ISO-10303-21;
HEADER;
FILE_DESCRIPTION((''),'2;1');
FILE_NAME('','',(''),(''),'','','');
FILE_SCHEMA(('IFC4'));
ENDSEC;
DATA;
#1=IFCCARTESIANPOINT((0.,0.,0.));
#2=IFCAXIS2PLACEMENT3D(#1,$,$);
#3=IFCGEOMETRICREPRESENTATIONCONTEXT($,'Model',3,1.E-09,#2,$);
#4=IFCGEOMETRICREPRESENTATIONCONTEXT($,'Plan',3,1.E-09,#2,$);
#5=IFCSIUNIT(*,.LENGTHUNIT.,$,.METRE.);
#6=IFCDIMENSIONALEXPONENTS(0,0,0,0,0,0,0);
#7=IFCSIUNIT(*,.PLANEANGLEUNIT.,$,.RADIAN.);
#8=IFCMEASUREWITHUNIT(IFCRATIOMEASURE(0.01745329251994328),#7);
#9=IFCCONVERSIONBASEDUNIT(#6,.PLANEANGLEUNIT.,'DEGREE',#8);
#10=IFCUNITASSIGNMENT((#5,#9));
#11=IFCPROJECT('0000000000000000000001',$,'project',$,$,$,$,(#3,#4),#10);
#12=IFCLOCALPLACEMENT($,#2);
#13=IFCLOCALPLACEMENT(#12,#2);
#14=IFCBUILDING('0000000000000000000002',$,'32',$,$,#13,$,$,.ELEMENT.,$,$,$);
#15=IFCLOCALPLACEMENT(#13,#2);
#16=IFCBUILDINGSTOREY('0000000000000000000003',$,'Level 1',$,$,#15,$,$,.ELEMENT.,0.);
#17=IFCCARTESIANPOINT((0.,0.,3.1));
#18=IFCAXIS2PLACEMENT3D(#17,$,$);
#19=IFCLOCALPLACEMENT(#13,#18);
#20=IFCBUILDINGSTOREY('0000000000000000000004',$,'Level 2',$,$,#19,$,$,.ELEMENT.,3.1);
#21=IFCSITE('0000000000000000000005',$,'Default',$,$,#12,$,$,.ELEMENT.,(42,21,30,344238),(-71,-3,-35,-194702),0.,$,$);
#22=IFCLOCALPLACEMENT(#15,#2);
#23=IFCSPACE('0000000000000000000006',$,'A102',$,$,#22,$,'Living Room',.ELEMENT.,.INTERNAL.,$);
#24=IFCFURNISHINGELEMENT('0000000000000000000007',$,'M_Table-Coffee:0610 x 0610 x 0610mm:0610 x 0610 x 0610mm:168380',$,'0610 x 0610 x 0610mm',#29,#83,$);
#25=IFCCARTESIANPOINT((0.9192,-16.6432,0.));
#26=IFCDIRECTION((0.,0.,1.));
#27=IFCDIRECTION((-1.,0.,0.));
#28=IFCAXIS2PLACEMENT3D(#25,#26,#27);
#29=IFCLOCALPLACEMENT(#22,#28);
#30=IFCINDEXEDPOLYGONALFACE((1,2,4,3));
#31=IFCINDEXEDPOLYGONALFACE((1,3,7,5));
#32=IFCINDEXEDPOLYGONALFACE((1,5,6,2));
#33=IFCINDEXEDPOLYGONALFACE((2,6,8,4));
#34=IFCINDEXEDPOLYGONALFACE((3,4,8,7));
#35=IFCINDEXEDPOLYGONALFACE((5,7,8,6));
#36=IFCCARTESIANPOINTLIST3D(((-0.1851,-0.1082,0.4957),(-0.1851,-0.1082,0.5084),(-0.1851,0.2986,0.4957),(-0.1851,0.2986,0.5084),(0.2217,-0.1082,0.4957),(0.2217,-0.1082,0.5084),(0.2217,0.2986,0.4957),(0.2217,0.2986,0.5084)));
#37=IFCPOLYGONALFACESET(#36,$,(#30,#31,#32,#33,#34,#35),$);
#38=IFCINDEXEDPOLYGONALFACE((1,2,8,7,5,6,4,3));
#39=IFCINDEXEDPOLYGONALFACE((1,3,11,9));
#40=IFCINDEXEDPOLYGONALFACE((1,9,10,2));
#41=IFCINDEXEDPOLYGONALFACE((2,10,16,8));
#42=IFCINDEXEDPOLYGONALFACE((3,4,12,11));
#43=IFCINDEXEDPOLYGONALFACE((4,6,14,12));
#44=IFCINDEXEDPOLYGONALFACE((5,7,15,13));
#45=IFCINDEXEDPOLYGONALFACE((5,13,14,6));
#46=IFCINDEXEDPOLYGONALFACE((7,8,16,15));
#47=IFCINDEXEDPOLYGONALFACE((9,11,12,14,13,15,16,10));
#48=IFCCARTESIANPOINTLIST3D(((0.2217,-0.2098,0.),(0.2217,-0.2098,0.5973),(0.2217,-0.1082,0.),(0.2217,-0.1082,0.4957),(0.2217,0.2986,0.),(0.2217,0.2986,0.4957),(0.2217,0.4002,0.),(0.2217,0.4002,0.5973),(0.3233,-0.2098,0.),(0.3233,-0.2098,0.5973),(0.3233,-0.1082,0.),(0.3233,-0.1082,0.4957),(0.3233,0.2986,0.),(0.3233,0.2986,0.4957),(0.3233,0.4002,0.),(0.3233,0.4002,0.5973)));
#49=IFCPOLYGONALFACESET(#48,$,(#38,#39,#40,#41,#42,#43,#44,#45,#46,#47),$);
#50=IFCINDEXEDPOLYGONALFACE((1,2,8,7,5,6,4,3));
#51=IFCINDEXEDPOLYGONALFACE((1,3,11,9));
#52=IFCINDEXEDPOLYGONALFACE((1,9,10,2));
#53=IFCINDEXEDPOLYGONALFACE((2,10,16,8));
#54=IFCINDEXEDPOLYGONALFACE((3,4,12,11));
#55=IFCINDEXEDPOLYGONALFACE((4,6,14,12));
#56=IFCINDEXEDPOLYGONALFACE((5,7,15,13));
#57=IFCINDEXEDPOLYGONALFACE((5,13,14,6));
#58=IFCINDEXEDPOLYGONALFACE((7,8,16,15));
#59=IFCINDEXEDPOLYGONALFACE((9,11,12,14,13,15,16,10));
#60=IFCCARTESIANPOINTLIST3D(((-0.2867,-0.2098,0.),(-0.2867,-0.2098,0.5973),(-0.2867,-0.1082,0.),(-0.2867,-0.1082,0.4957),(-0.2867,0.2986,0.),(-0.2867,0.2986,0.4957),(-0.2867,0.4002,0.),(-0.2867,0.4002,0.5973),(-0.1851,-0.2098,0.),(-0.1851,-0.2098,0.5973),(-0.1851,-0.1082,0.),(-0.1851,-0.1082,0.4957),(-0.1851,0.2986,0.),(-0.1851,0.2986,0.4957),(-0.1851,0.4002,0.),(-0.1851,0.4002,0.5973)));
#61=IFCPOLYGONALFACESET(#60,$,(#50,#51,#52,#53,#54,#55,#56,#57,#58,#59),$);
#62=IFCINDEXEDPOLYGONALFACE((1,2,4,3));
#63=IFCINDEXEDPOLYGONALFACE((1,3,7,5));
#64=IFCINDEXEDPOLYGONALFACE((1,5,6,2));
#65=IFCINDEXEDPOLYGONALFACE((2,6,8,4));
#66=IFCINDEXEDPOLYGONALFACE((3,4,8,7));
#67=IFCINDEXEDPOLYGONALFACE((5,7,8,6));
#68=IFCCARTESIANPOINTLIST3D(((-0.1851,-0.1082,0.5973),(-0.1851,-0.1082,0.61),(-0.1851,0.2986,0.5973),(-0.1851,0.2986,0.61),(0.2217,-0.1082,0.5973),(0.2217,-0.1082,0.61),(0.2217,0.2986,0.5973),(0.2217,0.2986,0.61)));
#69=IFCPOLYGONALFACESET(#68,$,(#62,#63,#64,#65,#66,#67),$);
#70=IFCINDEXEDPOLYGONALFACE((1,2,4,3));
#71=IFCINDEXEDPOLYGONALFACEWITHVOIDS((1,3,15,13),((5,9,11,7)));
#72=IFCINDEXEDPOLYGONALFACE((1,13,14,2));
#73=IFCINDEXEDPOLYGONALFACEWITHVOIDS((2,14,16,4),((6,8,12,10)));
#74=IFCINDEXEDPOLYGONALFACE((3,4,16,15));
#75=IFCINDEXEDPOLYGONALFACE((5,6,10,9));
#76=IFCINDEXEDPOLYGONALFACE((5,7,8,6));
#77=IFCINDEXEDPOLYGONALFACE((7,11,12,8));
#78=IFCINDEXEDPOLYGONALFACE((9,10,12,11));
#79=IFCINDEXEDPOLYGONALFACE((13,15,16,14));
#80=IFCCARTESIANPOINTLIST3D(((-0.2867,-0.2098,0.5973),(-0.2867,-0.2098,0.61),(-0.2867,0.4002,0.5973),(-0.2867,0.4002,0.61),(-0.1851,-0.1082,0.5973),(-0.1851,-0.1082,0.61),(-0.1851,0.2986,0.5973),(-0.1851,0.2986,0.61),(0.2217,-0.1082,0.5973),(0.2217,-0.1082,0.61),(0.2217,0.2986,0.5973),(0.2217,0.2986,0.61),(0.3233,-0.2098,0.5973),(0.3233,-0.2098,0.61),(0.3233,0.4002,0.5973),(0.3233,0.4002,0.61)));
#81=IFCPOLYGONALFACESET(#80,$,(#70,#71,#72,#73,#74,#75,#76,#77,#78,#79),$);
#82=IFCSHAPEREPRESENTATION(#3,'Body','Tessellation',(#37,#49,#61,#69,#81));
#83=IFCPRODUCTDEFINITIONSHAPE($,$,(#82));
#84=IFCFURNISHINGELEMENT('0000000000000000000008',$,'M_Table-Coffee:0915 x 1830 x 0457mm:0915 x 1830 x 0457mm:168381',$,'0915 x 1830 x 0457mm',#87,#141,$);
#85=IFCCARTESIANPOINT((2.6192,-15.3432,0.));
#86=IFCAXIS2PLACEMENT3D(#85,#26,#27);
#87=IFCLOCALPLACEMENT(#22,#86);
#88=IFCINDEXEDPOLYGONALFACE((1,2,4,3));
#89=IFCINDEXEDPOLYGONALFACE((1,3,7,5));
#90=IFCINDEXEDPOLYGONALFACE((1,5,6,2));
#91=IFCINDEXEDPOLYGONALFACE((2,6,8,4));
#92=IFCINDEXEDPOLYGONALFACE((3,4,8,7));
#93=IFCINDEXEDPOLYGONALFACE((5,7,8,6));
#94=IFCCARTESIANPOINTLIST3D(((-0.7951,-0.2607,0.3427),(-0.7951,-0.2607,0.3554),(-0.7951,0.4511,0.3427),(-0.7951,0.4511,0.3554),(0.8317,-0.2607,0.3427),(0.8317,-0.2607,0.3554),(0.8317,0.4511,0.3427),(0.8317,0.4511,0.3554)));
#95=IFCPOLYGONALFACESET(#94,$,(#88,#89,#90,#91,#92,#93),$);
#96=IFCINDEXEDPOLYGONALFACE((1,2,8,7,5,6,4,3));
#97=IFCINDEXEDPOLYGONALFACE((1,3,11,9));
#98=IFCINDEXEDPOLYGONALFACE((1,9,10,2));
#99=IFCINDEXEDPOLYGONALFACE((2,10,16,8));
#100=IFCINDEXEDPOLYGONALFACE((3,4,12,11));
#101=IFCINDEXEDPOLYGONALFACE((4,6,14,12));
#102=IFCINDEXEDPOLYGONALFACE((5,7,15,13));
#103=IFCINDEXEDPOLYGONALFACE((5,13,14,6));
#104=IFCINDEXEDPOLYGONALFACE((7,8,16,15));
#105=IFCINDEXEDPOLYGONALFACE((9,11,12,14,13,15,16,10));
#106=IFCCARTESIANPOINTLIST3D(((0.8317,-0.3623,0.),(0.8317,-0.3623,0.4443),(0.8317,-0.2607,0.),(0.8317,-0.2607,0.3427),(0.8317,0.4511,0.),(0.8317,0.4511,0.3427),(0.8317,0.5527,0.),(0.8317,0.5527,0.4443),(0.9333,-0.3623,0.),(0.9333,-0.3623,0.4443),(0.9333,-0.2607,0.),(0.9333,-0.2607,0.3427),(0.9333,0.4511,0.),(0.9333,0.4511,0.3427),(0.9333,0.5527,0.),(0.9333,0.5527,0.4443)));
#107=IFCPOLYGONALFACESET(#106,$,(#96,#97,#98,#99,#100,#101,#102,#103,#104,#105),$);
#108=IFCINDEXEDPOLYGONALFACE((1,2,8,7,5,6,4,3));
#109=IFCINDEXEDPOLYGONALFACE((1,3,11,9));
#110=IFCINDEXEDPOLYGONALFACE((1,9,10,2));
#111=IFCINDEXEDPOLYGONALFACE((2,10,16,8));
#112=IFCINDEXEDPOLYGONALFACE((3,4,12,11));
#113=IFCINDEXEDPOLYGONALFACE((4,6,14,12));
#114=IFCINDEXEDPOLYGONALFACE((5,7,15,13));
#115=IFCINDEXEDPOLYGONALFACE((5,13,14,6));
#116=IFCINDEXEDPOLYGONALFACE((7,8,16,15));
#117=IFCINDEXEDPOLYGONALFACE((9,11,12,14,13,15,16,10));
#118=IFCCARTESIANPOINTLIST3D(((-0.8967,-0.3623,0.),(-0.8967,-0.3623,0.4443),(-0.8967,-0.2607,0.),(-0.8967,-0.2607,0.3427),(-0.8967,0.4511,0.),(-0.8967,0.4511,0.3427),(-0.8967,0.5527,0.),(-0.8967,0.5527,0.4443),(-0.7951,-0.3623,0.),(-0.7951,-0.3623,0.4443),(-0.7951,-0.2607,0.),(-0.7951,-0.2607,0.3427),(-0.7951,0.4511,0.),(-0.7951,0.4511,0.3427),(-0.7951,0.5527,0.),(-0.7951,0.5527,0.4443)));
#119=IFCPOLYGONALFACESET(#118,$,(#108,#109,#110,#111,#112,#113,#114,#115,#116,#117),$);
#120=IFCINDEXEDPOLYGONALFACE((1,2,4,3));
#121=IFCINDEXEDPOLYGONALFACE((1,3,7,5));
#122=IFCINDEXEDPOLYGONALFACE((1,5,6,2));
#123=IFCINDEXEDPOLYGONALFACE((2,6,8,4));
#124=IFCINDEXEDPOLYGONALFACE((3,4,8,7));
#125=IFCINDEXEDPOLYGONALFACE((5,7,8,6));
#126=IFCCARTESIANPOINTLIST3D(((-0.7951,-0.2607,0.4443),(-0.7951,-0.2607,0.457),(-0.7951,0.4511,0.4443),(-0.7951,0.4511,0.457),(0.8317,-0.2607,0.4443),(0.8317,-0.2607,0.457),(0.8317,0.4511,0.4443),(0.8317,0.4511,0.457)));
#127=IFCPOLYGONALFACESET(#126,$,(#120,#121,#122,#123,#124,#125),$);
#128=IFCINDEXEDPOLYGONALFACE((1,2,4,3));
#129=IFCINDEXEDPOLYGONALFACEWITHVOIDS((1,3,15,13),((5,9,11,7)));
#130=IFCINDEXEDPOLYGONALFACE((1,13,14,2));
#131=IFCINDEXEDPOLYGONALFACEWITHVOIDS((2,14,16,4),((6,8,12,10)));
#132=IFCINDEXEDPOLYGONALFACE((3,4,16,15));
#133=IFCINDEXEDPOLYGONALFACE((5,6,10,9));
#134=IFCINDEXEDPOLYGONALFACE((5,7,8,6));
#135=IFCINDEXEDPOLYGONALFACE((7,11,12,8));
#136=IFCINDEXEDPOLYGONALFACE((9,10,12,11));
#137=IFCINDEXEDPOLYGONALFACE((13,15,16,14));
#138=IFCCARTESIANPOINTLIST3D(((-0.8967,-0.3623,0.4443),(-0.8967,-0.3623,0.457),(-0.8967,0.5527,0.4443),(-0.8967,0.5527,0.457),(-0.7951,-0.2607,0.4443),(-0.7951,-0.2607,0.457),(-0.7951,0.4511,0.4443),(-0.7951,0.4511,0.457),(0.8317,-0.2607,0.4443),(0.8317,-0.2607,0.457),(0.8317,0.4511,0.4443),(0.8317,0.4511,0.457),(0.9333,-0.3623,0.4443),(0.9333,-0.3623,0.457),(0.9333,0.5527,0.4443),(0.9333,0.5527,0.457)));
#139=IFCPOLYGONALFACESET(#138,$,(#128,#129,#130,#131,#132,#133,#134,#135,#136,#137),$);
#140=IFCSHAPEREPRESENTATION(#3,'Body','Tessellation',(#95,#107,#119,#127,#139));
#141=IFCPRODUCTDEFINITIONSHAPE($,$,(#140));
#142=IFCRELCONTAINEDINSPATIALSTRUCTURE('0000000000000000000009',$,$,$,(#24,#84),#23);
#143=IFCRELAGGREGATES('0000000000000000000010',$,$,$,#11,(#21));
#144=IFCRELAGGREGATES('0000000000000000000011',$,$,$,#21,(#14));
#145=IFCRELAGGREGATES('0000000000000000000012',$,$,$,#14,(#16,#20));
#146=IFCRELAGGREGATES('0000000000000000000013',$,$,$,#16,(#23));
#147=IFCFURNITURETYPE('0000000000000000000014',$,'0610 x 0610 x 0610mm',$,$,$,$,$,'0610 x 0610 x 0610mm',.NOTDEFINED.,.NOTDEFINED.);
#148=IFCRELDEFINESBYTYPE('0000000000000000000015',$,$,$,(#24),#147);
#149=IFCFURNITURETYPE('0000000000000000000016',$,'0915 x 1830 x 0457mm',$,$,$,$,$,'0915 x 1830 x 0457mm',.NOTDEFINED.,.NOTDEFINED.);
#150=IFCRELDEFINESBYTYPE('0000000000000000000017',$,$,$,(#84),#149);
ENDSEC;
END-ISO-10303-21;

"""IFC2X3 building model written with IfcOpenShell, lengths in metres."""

from ifc_helpers import new_model, entity, si_unit, converted_unit, frame, origin, origin_2d_with_axis, place, context, project, spatial, polyline, rectangle, outline, extrude, source, transform, mapped, type_object, type_shapes, element, save


model = new_model("IFC2X3")

# Units and contexts
model_context = context("Model", 3, precision=1e-09, world=origin())
plan_context = context("Plan", 3, precision=1e-09, world=origin())
ifc_project = project(units=[si_unit("LENGTHUNIT", "METRE"), converted_unit("PLANEANGLEUNIT", "DEGREE", entity("IfcRatioMeasure", 0.01745329251994328), si_unit("PLANEANGLEUNIT", "RADIAN"), dimensions=[0, 0, 0, 0, 0, 0, 0])], contexts=[model_context, plan_context])

# Site, building, storey
site_placement = place(None, origin())
site = spatial("IfcSite", under=ifc_project, at=site_placement, Name="Default", CompositionType="ELEMENT", RefLatitude=(42, 21, 30, 344238), RefLongitude=(-71, -3, -35, -194702), RefElevation=0.0)
building_placement = place(site_placement, origin())
building = spatial("IfcBuilding", under=site, at=building_placement, Name="32", CompositionType="ELEMENT")
storey_1_placement = place(building_placement, origin())
storey_1 = spatial("IfcBuildingStorey", under=building, at=storey_1_placement, Name="Level 1", CompositionType="ELEMENT", Elevation=0.0)

# Shared definitions
storey_2_placement = place(building_placement, frame((0.0, 0.0, 3.1)))
storey_2 = spatial("IfcBuildingStorey", under=building, at=storey_2_placement, Name="Level 2", CompositionType="ELEMENT", Elevation=3.1)

# Shared definitions
space_1_placement = place(storey_1_placement, origin())
space_1 = spatial("IfcSpace", under=storey_1, at=space_1_placement, Name="A102", LongName="Living Room", CompositionType="ELEMENT", InteriorOrExteriorSpace="INTERNAL")

# Furnishing elements
furniture_type_1 = type_object("IfcFurnitureType", Name="0610 x 0610 x 0610mm", ElementType="0610 x 0610 x 0610mm", AssemblyPlace="NOTDEFINED")
shared_shape_1 = source(origin(), model_context, "Body", "SweptSolid", [
    extrude(rectangle(XDim=0.4068, YDim=0.4068, at=origin_2d_with_axis()), frame((0.0183, 0.0952, 0.4957), z_axis=(0.0, 0.0, 1.0), x_axis=(-1.0, 0.0, 0.0)), (0.0, 0.0, 1.0), 0.0127),
    extrude(outline(polyline([(-0.2732, -0.305), (0.324, -0.305), (0.324, 0.305), (-0.2732, 0.305), (-0.2732, 0.2034), (0.2225, 0.2034), (0.2225, -0.2034), (-0.2732, -0.2034), (-0.2732, -0.305)])), frame((0.2217, 0.0952, 0.2732), z_axis=(1.0, 0.0, 0.0), x_axis=(0.0, 0.0, 1.0)), (0.0, 0.0, 1.0), 0.1016),
    extrude(outline(polyline([(-0.305, -0.3241), (0.305, -0.3241), (0.305, 0.2733), (0.2034, 0.2733), (0.2034, -0.2224), (-0.2034, -0.2224), (-0.2034, 0.2733), (-0.305, 0.2733), (-0.305, -0.3241)])), frame((-0.2867, 0.0952, 0.2733), z_axis=(1.0, 0.0, 0.0), x_axis=(0.0, -1.0, 0.0)), (0.0, 0.0, 1.0), 0.1016),
    extrude(rectangle(XDim=0.4068, YDim=0.4068, at=origin_2d_with_axis()), frame((0.0183, 0.0952, 0.5973), z_axis=(0.0, 0.0, 1.0), x_axis=(-1.0, 0.0, 0.0)), (0.0, 0.0, 1.0), 0.0127),
    extrude(outline(polyline([(-0.305, -0.305), (0.305, -0.305), (0.305, 0.305), (-0.305, 0.305), (-0.305, -0.305)]), holes=[polyline([(-0.2034, -0.2034), (-0.2034, 0.2034), (0.2034, 0.2034), (0.2034, -0.2034), (-0.2034, -0.2034)])]), frame((0.0183, 0.0952, 0.5973), z_axis=(0.0, 0.0, 1.0), x_axis=(-1.0, 0.0, 0.0)), (0.0, 0.0, 1.0), 0.0127),
])
type_shapes(furniture_type_1, [shared_shape_1])
for number, where, z_axis, x_axis, name in (
    (1, (0.9192, -16.6432, 0.0), (0.0, 0.0, 1.0), (-1.0, 0.0, 0.0), "M_Table-Coffee:0610 x 0610 x 0610mm:0610 x 0610 x 0610mm:168380"),
):
    element("IfcFurnishingElement", number, at=place(space_1_placement, frame(where, z_axis=z_axis, x_axis=x_axis)), inside=space_1, type_object=furniture_type_1, Name=name, ObjectType="0610 x 0610 x 0610mm", context=model_context, shape_type="MappedRepresentation", body=[
        mapped(shared_shape_1, transform((0.0, 0.0, 0.0), scale=1.0)),
    ])
furniture_type_2 = type_object("IfcFurnitureType", Name="0915 x 1830 x 0457mm", ElementType="0915 x 1830 x 0457mm", AssemblyPlace="NOTDEFINED")
shared_shape_2 = source(origin(), model_context, "Body", "SweptSolid", [
    extrude(rectangle(XDim=1.6268, YDim=0.7118, at=origin_2d_with_axis()), frame((0.0183, 0.0952, 0.3427), z_axis=(0.0, 0.0, 1.0), x_axis=(-1.0, 0.0, 0.0)), (0.0, 0.0, 1.0), 0.0127),
    extrude(outline(polyline([(-0.1967, -0.4575), (0.2475, -0.4575), (0.2475, 0.4575), (-0.1967, 0.4575), (-0.1967, 0.3559), (0.146, 0.3559), (0.146, -0.3559), (-0.1967, -0.3559), (-0.1967, -0.4575)])), frame((0.8317, 0.0952, 0.1967), z_axis=(1.0, 0.0, 0.0), x_axis=(0.0, 0.0, 1.0)), (0.0, 0.0, 1.0), 0.1016),
    extrude(outline(polyline([(-0.4575, -0.2476), (0.4575, -0.2476), (0.4575, 0.1968), (0.3559, 0.1968), (0.3559, -0.1459), (-0.3559, -0.1459), (-0.3559, 0.1968), (-0.4575, 0.1968), (-0.4575, -0.2476)])), frame((-0.8967, 0.0952, 0.1968), z_axis=(1.0, 0.0, 0.0), x_axis=(0.0, -1.0, 0.0)), (0.0, 0.0, 1.0), 0.1016),
    extrude(rectangle(XDim=1.6268, YDim=0.7118, at=origin_2d_with_axis()), frame((0.0183, 0.0952, 0.4443), z_axis=(0.0, 0.0, 1.0), x_axis=(-1.0, 0.0, 0.0)), (0.0, 0.0, 1.0), 0.0127),
    extrude(outline(polyline([(-0.915, -0.4575), (0.915, -0.4575), (0.915, 0.4575), (-0.915, 0.4575), (-0.915, -0.4575)]), holes=[polyline([(-0.8134, -0.3559), (-0.8134, 0.3559), (0.8134, 0.3559), (0.8134, -0.3559), (-0.8134, -0.3559)])]), frame((0.0183, 0.0952, 0.4443), z_axis=(0.0, 0.0, 1.0), x_axis=(-1.0, 0.0, 0.0)), (0.0, 0.0, 1.0), 0.0127),
])
type_shapes(furniture_type_2, [shared_shape_2])
furnishing_1_placement = place(space_1_placement, frame((2.6192, -15.3432, 0.0), z_axis=(0.0, 0.0, 1.0), x_axis=(-1.0, 0.0, 0.0)))
element("IfcFurnishingElement", 2, at=furnishing_1_placement, inside=space_1, type_object=furniture_type_2, Name="M_Table-Coffee:0915 x 1830 x 0457mm:0915 x 1830 x 0457mm:168381", ObjectType="0915 x 1830 x 0457mm", context=model_context, shape_type="MappedRepresentation", body=[
    mapped(shared_shape_2, transform((0.0, 0.0, 0.0), scale=1.0)),
])

save(model, "model.ifc")
